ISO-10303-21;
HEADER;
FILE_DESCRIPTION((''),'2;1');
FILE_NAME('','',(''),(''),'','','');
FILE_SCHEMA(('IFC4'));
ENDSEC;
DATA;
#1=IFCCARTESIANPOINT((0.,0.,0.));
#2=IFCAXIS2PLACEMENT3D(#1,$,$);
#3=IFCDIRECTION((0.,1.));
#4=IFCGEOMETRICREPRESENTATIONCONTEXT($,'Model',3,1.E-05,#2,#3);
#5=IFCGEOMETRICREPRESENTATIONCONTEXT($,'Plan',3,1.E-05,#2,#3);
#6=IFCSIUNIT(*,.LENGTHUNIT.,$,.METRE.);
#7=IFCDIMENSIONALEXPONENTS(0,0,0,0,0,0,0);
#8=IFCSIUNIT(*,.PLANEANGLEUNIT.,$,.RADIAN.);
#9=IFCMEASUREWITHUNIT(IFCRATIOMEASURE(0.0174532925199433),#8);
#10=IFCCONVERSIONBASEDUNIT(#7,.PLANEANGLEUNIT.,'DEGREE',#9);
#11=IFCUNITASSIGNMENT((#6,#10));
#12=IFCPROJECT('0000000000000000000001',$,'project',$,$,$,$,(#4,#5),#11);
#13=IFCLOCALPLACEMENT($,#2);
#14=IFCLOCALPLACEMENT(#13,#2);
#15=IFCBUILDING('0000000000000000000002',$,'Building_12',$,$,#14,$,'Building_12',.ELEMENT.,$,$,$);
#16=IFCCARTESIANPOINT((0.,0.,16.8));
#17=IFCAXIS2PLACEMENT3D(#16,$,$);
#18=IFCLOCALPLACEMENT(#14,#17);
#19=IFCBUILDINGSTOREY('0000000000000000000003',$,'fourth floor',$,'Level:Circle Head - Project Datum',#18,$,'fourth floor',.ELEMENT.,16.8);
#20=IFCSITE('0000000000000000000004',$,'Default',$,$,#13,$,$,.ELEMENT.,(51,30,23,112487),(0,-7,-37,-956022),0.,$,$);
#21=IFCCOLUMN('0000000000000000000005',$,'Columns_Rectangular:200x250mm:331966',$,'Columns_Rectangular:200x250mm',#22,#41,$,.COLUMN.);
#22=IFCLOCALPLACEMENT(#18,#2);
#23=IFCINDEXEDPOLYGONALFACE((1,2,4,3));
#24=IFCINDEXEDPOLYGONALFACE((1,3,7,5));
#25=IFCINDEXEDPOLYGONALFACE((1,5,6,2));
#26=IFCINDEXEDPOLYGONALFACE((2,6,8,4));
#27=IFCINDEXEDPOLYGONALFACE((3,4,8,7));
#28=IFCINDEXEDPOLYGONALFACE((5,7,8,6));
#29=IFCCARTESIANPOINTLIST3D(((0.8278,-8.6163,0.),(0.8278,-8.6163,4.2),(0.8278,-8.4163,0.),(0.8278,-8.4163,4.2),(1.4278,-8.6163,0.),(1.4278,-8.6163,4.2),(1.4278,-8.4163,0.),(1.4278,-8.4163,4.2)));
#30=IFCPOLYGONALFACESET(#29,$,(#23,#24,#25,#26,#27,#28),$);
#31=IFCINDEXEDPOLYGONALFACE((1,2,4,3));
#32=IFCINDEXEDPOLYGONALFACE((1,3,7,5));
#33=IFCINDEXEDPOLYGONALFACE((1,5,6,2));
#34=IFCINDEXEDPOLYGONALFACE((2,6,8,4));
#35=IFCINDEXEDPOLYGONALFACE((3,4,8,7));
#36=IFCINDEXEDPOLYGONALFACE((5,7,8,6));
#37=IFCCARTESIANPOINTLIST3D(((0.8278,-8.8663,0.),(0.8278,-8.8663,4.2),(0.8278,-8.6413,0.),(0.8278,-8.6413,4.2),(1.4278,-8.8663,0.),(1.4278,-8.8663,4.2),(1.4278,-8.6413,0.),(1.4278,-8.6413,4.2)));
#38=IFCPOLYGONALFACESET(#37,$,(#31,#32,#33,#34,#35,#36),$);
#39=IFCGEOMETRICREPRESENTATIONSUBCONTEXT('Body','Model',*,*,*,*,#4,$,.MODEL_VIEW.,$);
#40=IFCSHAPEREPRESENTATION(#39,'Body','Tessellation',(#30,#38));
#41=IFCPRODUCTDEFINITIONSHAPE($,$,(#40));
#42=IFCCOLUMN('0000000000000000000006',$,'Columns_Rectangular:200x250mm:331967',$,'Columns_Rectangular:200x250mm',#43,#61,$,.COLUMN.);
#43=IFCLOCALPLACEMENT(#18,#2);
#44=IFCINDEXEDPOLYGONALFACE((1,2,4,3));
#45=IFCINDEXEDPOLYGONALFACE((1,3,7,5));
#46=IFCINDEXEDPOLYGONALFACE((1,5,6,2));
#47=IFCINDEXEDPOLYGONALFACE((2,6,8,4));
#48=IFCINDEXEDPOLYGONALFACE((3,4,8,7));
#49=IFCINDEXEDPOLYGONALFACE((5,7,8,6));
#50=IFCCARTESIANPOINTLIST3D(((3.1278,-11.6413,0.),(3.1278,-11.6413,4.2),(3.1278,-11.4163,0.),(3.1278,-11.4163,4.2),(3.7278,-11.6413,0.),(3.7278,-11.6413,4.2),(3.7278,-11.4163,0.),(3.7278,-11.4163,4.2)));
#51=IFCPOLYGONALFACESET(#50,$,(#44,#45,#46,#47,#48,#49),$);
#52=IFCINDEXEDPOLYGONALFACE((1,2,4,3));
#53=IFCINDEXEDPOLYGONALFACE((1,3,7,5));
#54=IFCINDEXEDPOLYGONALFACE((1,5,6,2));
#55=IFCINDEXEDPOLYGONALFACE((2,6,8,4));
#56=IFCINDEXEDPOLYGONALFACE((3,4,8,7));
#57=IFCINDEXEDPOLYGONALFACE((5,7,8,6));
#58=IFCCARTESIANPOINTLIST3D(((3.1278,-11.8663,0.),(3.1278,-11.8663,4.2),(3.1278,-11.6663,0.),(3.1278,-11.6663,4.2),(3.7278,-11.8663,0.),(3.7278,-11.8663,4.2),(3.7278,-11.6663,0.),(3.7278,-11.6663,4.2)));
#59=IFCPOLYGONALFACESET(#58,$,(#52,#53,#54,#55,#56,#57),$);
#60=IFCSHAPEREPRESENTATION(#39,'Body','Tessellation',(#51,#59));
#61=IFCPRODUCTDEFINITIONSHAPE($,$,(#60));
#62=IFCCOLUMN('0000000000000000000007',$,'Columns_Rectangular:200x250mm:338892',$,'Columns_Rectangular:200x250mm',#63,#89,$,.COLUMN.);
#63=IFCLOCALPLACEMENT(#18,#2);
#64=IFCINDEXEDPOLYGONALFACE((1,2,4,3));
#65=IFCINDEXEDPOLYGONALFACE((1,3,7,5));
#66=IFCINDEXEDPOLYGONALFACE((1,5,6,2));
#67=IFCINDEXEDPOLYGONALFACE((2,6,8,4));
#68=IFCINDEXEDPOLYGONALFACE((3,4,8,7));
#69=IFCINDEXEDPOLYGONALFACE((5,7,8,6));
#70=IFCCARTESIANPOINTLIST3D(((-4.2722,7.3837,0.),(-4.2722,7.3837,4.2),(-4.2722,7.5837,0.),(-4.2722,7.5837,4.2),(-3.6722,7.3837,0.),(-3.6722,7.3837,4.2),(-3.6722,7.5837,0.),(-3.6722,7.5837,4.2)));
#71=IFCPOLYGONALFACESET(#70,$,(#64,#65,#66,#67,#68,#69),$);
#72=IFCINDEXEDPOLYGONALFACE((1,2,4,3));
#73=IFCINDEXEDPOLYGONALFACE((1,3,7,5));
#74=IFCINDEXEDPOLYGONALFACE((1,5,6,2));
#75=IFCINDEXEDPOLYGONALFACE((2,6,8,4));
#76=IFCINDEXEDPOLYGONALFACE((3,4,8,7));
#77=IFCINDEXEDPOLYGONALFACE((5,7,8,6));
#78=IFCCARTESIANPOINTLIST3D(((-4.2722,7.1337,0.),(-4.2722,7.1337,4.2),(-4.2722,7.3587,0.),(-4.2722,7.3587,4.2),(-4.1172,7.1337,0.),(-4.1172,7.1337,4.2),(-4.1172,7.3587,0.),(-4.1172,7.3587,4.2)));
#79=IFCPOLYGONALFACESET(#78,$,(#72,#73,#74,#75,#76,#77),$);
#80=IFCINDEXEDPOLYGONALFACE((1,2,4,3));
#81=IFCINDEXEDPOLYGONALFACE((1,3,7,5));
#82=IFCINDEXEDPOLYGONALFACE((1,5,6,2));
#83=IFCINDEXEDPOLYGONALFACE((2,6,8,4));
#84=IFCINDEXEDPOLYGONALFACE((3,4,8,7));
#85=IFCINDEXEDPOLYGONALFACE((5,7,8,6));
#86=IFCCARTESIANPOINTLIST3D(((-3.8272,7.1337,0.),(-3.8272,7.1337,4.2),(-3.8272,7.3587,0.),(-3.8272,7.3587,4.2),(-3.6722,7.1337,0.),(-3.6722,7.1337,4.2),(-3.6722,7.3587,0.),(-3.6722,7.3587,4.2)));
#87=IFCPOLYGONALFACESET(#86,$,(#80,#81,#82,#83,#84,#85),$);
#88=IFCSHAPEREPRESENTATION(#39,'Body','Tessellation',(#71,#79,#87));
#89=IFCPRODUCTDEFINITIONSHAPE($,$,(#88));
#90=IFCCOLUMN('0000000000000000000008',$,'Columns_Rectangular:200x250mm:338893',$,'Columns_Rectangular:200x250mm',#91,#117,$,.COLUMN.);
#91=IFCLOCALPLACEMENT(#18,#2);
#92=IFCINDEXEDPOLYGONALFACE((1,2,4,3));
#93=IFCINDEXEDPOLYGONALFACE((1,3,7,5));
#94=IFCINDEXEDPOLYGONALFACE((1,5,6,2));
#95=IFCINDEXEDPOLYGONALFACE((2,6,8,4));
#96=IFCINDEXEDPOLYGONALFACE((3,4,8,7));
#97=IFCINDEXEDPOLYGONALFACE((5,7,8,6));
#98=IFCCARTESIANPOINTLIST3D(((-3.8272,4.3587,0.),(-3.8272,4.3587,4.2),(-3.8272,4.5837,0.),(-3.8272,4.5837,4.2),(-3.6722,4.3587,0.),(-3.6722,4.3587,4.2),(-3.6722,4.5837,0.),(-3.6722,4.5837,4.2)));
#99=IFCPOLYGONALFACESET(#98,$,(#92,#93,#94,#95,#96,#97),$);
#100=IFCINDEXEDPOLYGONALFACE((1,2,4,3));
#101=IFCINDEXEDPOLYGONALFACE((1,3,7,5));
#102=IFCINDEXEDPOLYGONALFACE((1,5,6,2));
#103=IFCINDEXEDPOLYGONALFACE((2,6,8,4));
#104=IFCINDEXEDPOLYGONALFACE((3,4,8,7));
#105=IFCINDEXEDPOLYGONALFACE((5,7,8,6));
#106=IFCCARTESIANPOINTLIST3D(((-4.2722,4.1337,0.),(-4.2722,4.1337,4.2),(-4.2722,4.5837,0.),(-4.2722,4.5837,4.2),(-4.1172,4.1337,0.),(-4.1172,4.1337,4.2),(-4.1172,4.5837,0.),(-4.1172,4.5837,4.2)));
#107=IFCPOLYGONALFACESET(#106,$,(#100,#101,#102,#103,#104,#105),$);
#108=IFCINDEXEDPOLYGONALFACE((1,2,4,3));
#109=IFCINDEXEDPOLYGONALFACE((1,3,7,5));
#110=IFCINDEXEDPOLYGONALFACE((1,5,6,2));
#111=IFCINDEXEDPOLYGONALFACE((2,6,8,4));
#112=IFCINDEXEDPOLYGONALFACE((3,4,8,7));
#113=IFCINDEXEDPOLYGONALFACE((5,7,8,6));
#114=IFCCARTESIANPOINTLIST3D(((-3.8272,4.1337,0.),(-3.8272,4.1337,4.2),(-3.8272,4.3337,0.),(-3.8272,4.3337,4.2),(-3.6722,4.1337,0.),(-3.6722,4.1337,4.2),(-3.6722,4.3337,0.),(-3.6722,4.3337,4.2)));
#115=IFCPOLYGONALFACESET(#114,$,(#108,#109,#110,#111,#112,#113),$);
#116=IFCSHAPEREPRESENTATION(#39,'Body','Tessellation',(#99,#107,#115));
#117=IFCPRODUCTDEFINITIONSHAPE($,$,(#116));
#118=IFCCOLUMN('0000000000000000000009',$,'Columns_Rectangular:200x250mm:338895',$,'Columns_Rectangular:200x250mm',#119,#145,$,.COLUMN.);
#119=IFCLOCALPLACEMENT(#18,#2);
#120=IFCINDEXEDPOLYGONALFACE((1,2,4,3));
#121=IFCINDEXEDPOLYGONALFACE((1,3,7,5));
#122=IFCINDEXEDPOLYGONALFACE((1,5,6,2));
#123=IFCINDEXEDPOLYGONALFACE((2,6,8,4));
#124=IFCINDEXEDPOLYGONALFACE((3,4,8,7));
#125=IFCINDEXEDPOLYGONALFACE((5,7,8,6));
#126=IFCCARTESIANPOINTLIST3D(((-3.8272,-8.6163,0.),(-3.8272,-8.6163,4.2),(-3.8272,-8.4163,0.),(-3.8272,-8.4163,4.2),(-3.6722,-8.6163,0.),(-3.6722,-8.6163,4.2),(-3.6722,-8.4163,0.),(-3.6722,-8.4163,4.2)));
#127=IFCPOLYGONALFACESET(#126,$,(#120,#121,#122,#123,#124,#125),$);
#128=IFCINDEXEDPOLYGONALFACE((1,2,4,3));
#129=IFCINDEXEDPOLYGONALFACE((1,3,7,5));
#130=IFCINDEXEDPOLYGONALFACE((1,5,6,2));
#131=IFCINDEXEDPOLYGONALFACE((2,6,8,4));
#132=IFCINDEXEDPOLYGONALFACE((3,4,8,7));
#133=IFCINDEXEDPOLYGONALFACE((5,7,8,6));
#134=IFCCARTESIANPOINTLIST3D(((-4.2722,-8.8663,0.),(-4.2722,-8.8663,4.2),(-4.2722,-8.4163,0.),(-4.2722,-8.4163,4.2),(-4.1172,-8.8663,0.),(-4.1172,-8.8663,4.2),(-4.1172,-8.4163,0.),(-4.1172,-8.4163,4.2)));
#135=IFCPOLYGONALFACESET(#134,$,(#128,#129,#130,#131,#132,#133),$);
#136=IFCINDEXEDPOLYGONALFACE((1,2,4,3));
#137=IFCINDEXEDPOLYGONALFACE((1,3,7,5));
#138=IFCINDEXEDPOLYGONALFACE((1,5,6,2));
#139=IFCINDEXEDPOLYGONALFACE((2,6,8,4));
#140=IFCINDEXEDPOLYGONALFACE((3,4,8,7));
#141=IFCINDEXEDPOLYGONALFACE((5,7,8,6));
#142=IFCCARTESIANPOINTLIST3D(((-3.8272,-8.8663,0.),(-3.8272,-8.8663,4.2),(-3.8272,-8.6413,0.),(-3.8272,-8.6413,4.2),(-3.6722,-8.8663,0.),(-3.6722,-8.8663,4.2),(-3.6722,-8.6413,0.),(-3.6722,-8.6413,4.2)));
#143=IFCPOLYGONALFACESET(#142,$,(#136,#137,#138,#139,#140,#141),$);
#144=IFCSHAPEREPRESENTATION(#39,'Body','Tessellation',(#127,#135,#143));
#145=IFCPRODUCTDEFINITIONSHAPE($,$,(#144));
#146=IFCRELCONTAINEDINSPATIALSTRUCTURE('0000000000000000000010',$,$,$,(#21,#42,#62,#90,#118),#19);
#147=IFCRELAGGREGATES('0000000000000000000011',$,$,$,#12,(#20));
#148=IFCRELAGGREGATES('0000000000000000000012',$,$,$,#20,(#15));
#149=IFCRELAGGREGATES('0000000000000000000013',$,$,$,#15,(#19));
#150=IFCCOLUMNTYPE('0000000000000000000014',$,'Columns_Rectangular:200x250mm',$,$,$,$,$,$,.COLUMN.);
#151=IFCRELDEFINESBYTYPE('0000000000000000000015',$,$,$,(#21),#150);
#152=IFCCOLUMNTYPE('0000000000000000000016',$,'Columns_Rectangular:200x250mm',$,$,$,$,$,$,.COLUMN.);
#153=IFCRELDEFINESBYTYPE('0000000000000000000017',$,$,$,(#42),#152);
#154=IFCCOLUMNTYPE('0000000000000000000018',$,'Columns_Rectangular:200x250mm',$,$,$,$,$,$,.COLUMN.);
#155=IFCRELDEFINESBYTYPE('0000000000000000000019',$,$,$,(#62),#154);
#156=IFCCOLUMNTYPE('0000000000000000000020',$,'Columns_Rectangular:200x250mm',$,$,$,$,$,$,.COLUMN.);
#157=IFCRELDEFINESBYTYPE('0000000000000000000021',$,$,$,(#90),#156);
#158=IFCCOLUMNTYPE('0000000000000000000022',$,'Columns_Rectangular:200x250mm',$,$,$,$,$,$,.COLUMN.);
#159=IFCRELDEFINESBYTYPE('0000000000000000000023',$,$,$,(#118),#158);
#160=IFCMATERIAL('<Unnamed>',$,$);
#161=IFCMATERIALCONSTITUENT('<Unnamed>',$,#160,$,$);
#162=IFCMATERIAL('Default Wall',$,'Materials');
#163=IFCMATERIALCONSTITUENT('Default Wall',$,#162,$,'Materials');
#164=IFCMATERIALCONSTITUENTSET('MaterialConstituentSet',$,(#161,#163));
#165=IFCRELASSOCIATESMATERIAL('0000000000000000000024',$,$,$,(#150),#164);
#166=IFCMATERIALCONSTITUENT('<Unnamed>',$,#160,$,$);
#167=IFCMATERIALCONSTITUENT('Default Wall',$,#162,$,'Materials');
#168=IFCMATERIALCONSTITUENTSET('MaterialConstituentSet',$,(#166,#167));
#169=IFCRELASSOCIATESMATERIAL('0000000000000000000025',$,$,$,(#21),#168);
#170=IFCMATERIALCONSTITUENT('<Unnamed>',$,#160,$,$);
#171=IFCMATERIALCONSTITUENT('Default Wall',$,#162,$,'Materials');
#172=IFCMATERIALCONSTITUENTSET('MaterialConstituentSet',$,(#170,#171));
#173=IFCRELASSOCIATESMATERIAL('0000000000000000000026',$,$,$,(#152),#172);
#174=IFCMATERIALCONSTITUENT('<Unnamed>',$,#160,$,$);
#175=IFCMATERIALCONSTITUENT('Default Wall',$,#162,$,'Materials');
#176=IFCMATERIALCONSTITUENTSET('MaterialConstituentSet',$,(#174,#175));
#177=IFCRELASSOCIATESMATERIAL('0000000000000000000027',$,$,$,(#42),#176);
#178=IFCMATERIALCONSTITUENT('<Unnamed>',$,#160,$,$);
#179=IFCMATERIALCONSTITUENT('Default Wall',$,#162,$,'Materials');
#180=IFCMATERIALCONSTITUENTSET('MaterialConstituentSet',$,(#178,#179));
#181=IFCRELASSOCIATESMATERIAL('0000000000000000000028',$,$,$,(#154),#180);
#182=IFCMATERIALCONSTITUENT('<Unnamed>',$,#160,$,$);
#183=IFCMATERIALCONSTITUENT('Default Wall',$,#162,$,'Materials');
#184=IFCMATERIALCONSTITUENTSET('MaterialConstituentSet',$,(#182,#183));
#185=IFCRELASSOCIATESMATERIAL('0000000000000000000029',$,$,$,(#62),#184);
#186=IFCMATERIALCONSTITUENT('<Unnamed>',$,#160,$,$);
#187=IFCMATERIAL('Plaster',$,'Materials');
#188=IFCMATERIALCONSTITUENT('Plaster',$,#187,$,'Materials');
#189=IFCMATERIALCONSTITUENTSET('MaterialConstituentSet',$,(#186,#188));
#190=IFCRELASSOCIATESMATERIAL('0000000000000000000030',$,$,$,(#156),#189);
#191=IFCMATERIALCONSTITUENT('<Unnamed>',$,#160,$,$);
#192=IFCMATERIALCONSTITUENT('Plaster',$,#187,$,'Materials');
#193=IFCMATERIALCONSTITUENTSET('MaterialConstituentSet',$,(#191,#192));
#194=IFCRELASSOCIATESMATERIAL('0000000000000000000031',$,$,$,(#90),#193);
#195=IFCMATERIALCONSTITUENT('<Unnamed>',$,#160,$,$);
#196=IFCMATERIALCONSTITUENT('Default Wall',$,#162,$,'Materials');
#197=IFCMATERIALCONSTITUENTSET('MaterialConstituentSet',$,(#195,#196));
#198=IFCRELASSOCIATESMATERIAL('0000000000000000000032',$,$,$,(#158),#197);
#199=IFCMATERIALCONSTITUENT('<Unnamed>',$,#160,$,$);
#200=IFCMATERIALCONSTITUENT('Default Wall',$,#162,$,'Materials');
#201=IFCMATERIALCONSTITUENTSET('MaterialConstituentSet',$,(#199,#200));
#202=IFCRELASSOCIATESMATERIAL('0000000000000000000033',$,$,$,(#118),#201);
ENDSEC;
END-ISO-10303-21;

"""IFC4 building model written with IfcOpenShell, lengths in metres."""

from ifc_helpers import new_model, entity, si_unit, converted_unit, direction, frame, origin, place, context, subcontext, project, spatial, indexed_curve, outline, extrude, source, transform, mapped, material, constituent, constituent_set, type_object, type_shapes, element, save


model = new_model("IFC4")

# Units and contexts
model_context = context("Model", 3, precision=1e-05, world=origin(), true_north=direction((0.0, 1.0)))
plan_context = context("Plan", 3, precision=1e-05, world=origin(), true_north=direction((0.0, 1.0)))
body_context = subcontext(model_context, "Body", "Model", "MODEL_VIEW")
ifc_project = project(units=[si_unit("LENGTHUNIT", "METRE"), converted_unit("PLANEANGLEUNIT", "DEGREE", entity("IfcRatioMeasure", 0.0174532925199433), si_unit("PLANEANGLEUNIT", "RADIAN"), dimensions=[0, 0, 0, 0, 0, 0, 0])], contexts=[model_context, plan_context])

# Site, building, storey
site_placement = place(None, origin())
site = spatial("IfcSite", under=ifc_project, at=site_placement, Name="Default", CompositionType="ELEMENT", RefLatitude=(51, 30, 23, 112487), RefLongitude=(0, -7, -37, -956022), RefElevation=0.0)
building_placement = place(site_placement, origin())
building = spatial("IfcBuilding", under=site, at=building_placement, Name="Building_12", LongName="Building_12", CompositionType="ELEMENT")
storey_placement = place(building_placement, frame((0.0, 0.0, 16.8)))
storey = spatial("IfcBuildingStorey", under=building, at=storey_placement, Name="fourth floor", ObjectType="Level:Circle Head - Project Datum", LongName="fourth floor", CompositionType="ELEMENT", Elevation=16.8)

# Columns
ifc_material_1 = material(Name="<Unnamed>")
ifc_constituent_1 = constituent(ifc_material_1, Name="<Unnamed>")
ifc_material_2 = material(Name="Default Wall", Category="Materials")
ifc_constituent_2 = constituent(ifc_material_2, Name="Default Wall", Category="Materials")
ifc_constituent_set_1 = constituent_set(constituents=[ifc_constituent_1, ifc_constituent_2], Name="MaterialConstituentSet")
ifc_constituent_3 = constituent(ifc_material_1, Name="<Unnamed>")
ifc_constituent_4 = constituent(ifc_material_2, Name="Default Wall", Category="Materials")
ifc_constituent_set_2 = constituent_set(constituents=[ifc_constituent_3, ifc_constituent_4], Name="MaterialConstituentSet")
column_type_1 = type_object("IfcColumnType", Name="Columns_Rectangular:200x250mm", PredefinedType="COLUMN", material=ifc_constituent_set_2)
shared_shape_1 = source(origin(), body_context, "Body", "SweptSolid", [
    extrude(outline(indexed_curve([(-0.1, -0.3), (0.1, -0.3), (0.1, 0.3), (-0.1, 0.3), (-0.1, -0.3)], self_intersect=False)), frame((1.1278, -8.5163, 16.8), z_axis=(0.0, 0.0, 1.0), x_axis=(0.0, -1.0, 0.0)), (0.0, 0.0, 1.0), 4.2),
    extrude(outline(indexed_curve([(-0.1125, -0.3), (0.1125, -0.3), (0.1125, 0.3), (-0.1125, 0.3), (-0.1125, -0.3)], self_intersect=False)), frame((1.1278, -8.7538, 16.8), z_axis=(0.0, 0.0, 1.0), x_axis=(0.0, -1.0, 0.0)), (0.0, 0.0, 1.0), 4.2),
])
type_shapes(column_type_1, [shared_shape_1])
column_1_placement = place(storey_placement, frame((0.0, 0.0, -16.8)))
element("IfcColumn", 1, at=column_1_placement, inside=storey, type_object=column_type_1, material=ifc_constituent_set_1, Name="Columns_Rectangular:200x250mm:331966", ObjectType="Columns_Rectangular:200x250mm", PredefinedType="COLUMN", context=body_context, shape_type="MappedRepresentation", body=[
    mapped(shared_shape_1, transform((0.0, 0.0, 0.0), scale=1.0)),
])
ifc_constituent_5 = constituent(ifc_material_1, Name="<Unnamed>")
ifc_constituent_6 = constituent(ifc_material_2, Name="Default Wall", Category="Materials")
ifc_constituent_set_3 = constituent_set(constituents=[ifc_constituent_5, ifc_constituent_6], Name="MaterialConstituentSet")
ifc_constituent_7 = constituent(ifc_material_1, Name="<Unnamed>")
ifc_constituent_8 = constituent(ifc_material_2, Name="Default Wall", Category="Materials")
ifc_constituent_set_4 = constituent_set(constituents=[ifc_constituent_7, ifc_constituent_8], Name="MaterialConstituentSet")
column_type_2 = type_object("IfcColumnType", Name="Columns_Rectangular:200x250mm", PredefinedType="COLUMN", material=ifc_constituent_set_4)
shared_shape_2 = source(origin(), body_context, "Body", "SweptSolid", [
    extrude(outline(indexed_curve([(-0.1125, -0.3), (0.1125, -0.3), (0.1125, 0.3), (-0.1125, 0.3), (-0.1125, -0.3)], self_intersect=False)), frame((3.4278, -11.5288, 16.8), z_axis=(0.0, 0.0, 1.0), x_axis=(0.0, -1.0, 0.0)), (0.0, 0.0, 1.0), 4.2),
    extrude(outline(indexed_curve([(-0.1, -0.3), (0.1, -0.3), (0.1, 0.3), (-0.1, 0.3), (-0.1, -0.3)], self_intersect=False)), frame((3.4278, -11.7663, 16.8), z_axis=(0.0, 0.0, 1.0), x_axis=(0.0, -1.0, 0.0)), (0.0, 0.0, 1.0), 4.2),
])
type_shapes(column_type_2, [shared_shape_2])
column_2_placement = place(storey_placement, frame((0.0, 0.0, -16.8)))
element("IfcColumn", 2, at=column_2_placement, inside=storey, type_object=column_type_2, material=ifc_constituent_set_3, Name="Columns_Rectangular:200x250mm:331967", ObjectType="Columns_Rectangular:200x250mm", PredefinedType="COLUMN", context=body_context, shape_type="MappedRepresentation", body=[
    mapped(shared_shape_2, transform((0.0, 0.0, 0.0), scale=1.0)),
])
ifc_constituent_9 = constituent(ifc_material_1, Name="<Unnamed>")
ifc_constituent_10 = constituent(ifc_material_2, Name="Default Wall", Category="Materials")
ifc_constituent_set_5 = constituent_set(constituents=[ifc_constituent_9, ifc_constituent_10], Name="MaterialConstituentSet")
ifc_constituent_11 = constituent(ifc_material_1, Name="<Unnamed>")
ifc_constituent_12 = constituent(ifc_material_2, Name="Default Wall", Category="Materials")
ifc_constituent_set_6 = constituent_set(constituents=[ifc_constituent_11, ifc_constituent_12], Name="MaterialConstituentSet")
column_type_3 = type_object("IfcColumnType", Name="Columns_Rectangular:200x250mm", PredefinedType="COLUMN", material=ifc_constituent_set_6)
shared_shape_3 = source(origin(), body_context, "Body", "SweptSolid", [
    extrude(outline(indexed_curve([(-0.1, -0.3), (0.1, -0.3), (0.1, 0.3), (-0.1, 0.3), (-0.1, -0.3)], self_intersect=False)), frame((-3.9722, 7.4837, 16.8), z_axis=(0.0, 0.0, 1.0), x_axis=(0.0, -1.0, 0.0)), (0.0, 0.0, 1.0), 4.2),
    extrude(outline(indexed_curve([(-0.1125, -0.0775), (0.1125, -0.0775), (0.1125, 0.0775), (-0.1125, 0.0775), (-0.1125, -0.0775)], self_intersect=False)), frame((-4.1947, 7.2462, 16.8), z_axis=(0.0, 0.0, 1.0), x_axis=(0.0, -1.0, 0.0)), (0.0, 0.0, 1.0), 4.2),
    extrude(outline(indexed_curve([(-0.1125, -0.0775), (0.1125, -0.0775), (0.1125, 0.0775), (-0.1125, 0.0775), (-0.1125, -0.0775)], self_intersect=False)), frame((-3.7497, 7.2462, 16.8), z_axis=(0.0, 0.0, 1.0), x_axis=(0.0, -1.0, 0.0)), (0.0, 0.0, 1.0), 4.2),
])
type_shapes(column_type_3, [shared_shape_3])
column_3_placement = place(storey_placement, frame((0.0, 0.0, -16.8)))
element("IfcColumn", 3, at=column_3_placement, inside=storey, type_object=column_type_3, material=ifc_constituent_set_5, Name="Columns_Rectangular:200x250mm:338892", ObjectType="Columns_Rectangular:200x250mm", PredefinedType="COLUMN", context=body_context, shape_type="MappedRepresentation", body=[
    mapped(shared_shape_3, transform((0.0, 0.0, 0.0), scale=1.0)),
])
ifc_constituent_13 = constituent(ifc_material_1, Name="<Unnamed>")
ifc_material_3 = material(Name="Plaster", Category="Materials")
ifc_constituent_14 = constituent(ifc_material_3, Name="Plaster", Category="Materials")
ifc_constituent_set_7 = constituent_set(constituents=[ifc_constituent_13, ifc_constituent_14], Name="MaterialConstituentSet")
ifc_constituent_15 = constituent(ifc_material_1, Name="<Unnamed>")
ifc_constituent_16 = constituent(ifc_material_3, Name="Plaster", Category="Materials")
ifc_constituent_set_8 = constituent_set(constituents=[ifc_constituent_15, ifc_constituent_16], Name="MaterialConstituentSet")
column_type_4 = type_object("IfcColumnType", Name="Columns_Rectangular:200x250mm", PredefinedType="COLUMN", material=ifc_constituent_set_8)
shared_shape_4 = source(origin(), body_context, "Body", "SweptSolid", [
    extrude(outline(indexed_curve([(-0.1125, -0.0775), (0.1125, -0.0775), (0.1125, 0.0775), (-0.1125, 0.0775), (-0.1125, -0.0775)], self_intersect=False)), frame((-3.7497, 4.4712, 16.8), z_axis=(0.0, 0.0, 1.0), x_axis=(0.0, -1.0, 0.0)), (0.0, 0.0, 1.0), 4.2),
    extrude(outline(indexed_curve([(-0.225, -0.0775), (0.225, -0.0775), (0.225, 0.0775), (-0.225, 0.0775), (-0.225, -0.0775)], self_intersect=False)), frame((-4.1947, 4.3587, 16.8), z_axis=(0.0, 0.0, 1.0), x_axis=(0.0, -1.0, 0.0)), (0.0, 0.0, 1.0), 4.2),
    extrude(outline(indexed_curve([(-0.1, -0.0775), (0.1, -0.0775), (0.1, 0.0775), (-0.1, 0.0775), (-0.1, -0.0775)], self_intersect=False)), frame((-3.7497, 4.2337, 16.8), z_axis=(0.0, 0.0, 1.0), x_axis=(0.0, -1.0, 0.0)), (0.0, 0.0, 1.0), 4.2),
])
type_shapes(column_type_4, [shared_shape_4])
column_4_placement = place(storey_placement, frame((0.0, 0.0, -16.8)))
element("IfcColumn", 4, at=column_4_placement, inside=storey, type_object=column_type_4, material=ifc_constituent_set_7, Name="Columns_Rectangular:200x250mm:338893", ObjectType="Columns_Rectangular:200x250mm", PredefinedType="COLUMN", context=body_context, shape_type="MappedRepresentation", body=[
    mapped(shared_shape_4, transform((0.0, 0.0, 0.0), scale=1.0)),
])
ifc_constituent_17 = constituent(ifc_material_1, Name="<Unnamed>")
ifc_constituent_18 = constituent(ifc_material_2, Name="Default Wall", Category="Materials")
ifc_constituent_set_9 = constituent_set(constituents=[ifc_constituent_17, ifc_constituent_18], Name="MaterialConstituentSet")
ifc_constituent_19 = constituent(ifc_material_1, Name="<Unnamed>")
ifc_constituent_20 = constituent(ifc_material_2, Name="Default Wall", Category="Materials")
ifc_constituent_set_10 = constituent_set(constituents=[ifc_constituent_19, ifc_constituent_20], Name="MaterialConstituentSet")
column_type_5 = type_object("IfcColumnType", Name="Columns_Rectangular:200x250mm", PredefinedType="COLUMN", material=ifc_constituent_set_10)
shared_shape_5 = source(origin(), body_context, "Body", "SweptSolid", [
    extrude(outline(indexed_curve([(-0.1, -0.0775), (0.1, -0.0775), (0.1, 0.0775), (-0.1, 0.0775), (-0.1, -0.0775)], self_intersect=False)), frame((-3.7497, -8.5163, 16.8), z_axis=(0.0, 0.0, 1.0), x_axis=(0.0, -1.0, 0.0)), (0.0, 0.0, 1.0), 4.2),
    extrude(outline(indexed_curve([(-0.225, -0.0775), (0.225, -0.0775), (0.225, 0.0775), (-0.225, 0.0775), (-0.225, -0.0775)], self_intersect=False)), frame((-4.1947, -8.6413, 16.8), z_axis=(0.0, 0.0, 1.0), x_axis=(0.0, -1.0, 0.0)), (0.0, 0.0, 1.0), 4.2),
    extrude(outline(indexed_curve([(-0.1125, -0.0775), (0.1125, -0.0775), (0.1125, 0.0775), (-0.1125, 0.0775), (-0.1125, -0.0775)], self_intersect=False)), frame((-3.7497, -8.7538, 16.8), z_axis=(0.0, 0.0, 1.0), x_axis=(0.0, -1.0, 0.0)), (0.0, 0.0, 1.0), 4.2),
])
type_shapes(column_type_5, [shared_shape_5])
column_5_placement = place(storey_placement, frame((0.0, 0.0, -16.8)))
element("IfcColumn", 5, at=column_5_placement, inside=storey, type_object=column_type_5, material=ifc_constituent_set_9, Name="Columns_Rectangular:200x250mm:338895", ObjectType="Columns_Rectangular:200x250mm", PredefinedType="COLUMN", context=body_context, shape_type="MappedRepresentation", body=[
    mapped(shared_shape_5, transform((0.0, 0.0, 0.0), scale=1.0)),
])

save(model, "model.ifc")
